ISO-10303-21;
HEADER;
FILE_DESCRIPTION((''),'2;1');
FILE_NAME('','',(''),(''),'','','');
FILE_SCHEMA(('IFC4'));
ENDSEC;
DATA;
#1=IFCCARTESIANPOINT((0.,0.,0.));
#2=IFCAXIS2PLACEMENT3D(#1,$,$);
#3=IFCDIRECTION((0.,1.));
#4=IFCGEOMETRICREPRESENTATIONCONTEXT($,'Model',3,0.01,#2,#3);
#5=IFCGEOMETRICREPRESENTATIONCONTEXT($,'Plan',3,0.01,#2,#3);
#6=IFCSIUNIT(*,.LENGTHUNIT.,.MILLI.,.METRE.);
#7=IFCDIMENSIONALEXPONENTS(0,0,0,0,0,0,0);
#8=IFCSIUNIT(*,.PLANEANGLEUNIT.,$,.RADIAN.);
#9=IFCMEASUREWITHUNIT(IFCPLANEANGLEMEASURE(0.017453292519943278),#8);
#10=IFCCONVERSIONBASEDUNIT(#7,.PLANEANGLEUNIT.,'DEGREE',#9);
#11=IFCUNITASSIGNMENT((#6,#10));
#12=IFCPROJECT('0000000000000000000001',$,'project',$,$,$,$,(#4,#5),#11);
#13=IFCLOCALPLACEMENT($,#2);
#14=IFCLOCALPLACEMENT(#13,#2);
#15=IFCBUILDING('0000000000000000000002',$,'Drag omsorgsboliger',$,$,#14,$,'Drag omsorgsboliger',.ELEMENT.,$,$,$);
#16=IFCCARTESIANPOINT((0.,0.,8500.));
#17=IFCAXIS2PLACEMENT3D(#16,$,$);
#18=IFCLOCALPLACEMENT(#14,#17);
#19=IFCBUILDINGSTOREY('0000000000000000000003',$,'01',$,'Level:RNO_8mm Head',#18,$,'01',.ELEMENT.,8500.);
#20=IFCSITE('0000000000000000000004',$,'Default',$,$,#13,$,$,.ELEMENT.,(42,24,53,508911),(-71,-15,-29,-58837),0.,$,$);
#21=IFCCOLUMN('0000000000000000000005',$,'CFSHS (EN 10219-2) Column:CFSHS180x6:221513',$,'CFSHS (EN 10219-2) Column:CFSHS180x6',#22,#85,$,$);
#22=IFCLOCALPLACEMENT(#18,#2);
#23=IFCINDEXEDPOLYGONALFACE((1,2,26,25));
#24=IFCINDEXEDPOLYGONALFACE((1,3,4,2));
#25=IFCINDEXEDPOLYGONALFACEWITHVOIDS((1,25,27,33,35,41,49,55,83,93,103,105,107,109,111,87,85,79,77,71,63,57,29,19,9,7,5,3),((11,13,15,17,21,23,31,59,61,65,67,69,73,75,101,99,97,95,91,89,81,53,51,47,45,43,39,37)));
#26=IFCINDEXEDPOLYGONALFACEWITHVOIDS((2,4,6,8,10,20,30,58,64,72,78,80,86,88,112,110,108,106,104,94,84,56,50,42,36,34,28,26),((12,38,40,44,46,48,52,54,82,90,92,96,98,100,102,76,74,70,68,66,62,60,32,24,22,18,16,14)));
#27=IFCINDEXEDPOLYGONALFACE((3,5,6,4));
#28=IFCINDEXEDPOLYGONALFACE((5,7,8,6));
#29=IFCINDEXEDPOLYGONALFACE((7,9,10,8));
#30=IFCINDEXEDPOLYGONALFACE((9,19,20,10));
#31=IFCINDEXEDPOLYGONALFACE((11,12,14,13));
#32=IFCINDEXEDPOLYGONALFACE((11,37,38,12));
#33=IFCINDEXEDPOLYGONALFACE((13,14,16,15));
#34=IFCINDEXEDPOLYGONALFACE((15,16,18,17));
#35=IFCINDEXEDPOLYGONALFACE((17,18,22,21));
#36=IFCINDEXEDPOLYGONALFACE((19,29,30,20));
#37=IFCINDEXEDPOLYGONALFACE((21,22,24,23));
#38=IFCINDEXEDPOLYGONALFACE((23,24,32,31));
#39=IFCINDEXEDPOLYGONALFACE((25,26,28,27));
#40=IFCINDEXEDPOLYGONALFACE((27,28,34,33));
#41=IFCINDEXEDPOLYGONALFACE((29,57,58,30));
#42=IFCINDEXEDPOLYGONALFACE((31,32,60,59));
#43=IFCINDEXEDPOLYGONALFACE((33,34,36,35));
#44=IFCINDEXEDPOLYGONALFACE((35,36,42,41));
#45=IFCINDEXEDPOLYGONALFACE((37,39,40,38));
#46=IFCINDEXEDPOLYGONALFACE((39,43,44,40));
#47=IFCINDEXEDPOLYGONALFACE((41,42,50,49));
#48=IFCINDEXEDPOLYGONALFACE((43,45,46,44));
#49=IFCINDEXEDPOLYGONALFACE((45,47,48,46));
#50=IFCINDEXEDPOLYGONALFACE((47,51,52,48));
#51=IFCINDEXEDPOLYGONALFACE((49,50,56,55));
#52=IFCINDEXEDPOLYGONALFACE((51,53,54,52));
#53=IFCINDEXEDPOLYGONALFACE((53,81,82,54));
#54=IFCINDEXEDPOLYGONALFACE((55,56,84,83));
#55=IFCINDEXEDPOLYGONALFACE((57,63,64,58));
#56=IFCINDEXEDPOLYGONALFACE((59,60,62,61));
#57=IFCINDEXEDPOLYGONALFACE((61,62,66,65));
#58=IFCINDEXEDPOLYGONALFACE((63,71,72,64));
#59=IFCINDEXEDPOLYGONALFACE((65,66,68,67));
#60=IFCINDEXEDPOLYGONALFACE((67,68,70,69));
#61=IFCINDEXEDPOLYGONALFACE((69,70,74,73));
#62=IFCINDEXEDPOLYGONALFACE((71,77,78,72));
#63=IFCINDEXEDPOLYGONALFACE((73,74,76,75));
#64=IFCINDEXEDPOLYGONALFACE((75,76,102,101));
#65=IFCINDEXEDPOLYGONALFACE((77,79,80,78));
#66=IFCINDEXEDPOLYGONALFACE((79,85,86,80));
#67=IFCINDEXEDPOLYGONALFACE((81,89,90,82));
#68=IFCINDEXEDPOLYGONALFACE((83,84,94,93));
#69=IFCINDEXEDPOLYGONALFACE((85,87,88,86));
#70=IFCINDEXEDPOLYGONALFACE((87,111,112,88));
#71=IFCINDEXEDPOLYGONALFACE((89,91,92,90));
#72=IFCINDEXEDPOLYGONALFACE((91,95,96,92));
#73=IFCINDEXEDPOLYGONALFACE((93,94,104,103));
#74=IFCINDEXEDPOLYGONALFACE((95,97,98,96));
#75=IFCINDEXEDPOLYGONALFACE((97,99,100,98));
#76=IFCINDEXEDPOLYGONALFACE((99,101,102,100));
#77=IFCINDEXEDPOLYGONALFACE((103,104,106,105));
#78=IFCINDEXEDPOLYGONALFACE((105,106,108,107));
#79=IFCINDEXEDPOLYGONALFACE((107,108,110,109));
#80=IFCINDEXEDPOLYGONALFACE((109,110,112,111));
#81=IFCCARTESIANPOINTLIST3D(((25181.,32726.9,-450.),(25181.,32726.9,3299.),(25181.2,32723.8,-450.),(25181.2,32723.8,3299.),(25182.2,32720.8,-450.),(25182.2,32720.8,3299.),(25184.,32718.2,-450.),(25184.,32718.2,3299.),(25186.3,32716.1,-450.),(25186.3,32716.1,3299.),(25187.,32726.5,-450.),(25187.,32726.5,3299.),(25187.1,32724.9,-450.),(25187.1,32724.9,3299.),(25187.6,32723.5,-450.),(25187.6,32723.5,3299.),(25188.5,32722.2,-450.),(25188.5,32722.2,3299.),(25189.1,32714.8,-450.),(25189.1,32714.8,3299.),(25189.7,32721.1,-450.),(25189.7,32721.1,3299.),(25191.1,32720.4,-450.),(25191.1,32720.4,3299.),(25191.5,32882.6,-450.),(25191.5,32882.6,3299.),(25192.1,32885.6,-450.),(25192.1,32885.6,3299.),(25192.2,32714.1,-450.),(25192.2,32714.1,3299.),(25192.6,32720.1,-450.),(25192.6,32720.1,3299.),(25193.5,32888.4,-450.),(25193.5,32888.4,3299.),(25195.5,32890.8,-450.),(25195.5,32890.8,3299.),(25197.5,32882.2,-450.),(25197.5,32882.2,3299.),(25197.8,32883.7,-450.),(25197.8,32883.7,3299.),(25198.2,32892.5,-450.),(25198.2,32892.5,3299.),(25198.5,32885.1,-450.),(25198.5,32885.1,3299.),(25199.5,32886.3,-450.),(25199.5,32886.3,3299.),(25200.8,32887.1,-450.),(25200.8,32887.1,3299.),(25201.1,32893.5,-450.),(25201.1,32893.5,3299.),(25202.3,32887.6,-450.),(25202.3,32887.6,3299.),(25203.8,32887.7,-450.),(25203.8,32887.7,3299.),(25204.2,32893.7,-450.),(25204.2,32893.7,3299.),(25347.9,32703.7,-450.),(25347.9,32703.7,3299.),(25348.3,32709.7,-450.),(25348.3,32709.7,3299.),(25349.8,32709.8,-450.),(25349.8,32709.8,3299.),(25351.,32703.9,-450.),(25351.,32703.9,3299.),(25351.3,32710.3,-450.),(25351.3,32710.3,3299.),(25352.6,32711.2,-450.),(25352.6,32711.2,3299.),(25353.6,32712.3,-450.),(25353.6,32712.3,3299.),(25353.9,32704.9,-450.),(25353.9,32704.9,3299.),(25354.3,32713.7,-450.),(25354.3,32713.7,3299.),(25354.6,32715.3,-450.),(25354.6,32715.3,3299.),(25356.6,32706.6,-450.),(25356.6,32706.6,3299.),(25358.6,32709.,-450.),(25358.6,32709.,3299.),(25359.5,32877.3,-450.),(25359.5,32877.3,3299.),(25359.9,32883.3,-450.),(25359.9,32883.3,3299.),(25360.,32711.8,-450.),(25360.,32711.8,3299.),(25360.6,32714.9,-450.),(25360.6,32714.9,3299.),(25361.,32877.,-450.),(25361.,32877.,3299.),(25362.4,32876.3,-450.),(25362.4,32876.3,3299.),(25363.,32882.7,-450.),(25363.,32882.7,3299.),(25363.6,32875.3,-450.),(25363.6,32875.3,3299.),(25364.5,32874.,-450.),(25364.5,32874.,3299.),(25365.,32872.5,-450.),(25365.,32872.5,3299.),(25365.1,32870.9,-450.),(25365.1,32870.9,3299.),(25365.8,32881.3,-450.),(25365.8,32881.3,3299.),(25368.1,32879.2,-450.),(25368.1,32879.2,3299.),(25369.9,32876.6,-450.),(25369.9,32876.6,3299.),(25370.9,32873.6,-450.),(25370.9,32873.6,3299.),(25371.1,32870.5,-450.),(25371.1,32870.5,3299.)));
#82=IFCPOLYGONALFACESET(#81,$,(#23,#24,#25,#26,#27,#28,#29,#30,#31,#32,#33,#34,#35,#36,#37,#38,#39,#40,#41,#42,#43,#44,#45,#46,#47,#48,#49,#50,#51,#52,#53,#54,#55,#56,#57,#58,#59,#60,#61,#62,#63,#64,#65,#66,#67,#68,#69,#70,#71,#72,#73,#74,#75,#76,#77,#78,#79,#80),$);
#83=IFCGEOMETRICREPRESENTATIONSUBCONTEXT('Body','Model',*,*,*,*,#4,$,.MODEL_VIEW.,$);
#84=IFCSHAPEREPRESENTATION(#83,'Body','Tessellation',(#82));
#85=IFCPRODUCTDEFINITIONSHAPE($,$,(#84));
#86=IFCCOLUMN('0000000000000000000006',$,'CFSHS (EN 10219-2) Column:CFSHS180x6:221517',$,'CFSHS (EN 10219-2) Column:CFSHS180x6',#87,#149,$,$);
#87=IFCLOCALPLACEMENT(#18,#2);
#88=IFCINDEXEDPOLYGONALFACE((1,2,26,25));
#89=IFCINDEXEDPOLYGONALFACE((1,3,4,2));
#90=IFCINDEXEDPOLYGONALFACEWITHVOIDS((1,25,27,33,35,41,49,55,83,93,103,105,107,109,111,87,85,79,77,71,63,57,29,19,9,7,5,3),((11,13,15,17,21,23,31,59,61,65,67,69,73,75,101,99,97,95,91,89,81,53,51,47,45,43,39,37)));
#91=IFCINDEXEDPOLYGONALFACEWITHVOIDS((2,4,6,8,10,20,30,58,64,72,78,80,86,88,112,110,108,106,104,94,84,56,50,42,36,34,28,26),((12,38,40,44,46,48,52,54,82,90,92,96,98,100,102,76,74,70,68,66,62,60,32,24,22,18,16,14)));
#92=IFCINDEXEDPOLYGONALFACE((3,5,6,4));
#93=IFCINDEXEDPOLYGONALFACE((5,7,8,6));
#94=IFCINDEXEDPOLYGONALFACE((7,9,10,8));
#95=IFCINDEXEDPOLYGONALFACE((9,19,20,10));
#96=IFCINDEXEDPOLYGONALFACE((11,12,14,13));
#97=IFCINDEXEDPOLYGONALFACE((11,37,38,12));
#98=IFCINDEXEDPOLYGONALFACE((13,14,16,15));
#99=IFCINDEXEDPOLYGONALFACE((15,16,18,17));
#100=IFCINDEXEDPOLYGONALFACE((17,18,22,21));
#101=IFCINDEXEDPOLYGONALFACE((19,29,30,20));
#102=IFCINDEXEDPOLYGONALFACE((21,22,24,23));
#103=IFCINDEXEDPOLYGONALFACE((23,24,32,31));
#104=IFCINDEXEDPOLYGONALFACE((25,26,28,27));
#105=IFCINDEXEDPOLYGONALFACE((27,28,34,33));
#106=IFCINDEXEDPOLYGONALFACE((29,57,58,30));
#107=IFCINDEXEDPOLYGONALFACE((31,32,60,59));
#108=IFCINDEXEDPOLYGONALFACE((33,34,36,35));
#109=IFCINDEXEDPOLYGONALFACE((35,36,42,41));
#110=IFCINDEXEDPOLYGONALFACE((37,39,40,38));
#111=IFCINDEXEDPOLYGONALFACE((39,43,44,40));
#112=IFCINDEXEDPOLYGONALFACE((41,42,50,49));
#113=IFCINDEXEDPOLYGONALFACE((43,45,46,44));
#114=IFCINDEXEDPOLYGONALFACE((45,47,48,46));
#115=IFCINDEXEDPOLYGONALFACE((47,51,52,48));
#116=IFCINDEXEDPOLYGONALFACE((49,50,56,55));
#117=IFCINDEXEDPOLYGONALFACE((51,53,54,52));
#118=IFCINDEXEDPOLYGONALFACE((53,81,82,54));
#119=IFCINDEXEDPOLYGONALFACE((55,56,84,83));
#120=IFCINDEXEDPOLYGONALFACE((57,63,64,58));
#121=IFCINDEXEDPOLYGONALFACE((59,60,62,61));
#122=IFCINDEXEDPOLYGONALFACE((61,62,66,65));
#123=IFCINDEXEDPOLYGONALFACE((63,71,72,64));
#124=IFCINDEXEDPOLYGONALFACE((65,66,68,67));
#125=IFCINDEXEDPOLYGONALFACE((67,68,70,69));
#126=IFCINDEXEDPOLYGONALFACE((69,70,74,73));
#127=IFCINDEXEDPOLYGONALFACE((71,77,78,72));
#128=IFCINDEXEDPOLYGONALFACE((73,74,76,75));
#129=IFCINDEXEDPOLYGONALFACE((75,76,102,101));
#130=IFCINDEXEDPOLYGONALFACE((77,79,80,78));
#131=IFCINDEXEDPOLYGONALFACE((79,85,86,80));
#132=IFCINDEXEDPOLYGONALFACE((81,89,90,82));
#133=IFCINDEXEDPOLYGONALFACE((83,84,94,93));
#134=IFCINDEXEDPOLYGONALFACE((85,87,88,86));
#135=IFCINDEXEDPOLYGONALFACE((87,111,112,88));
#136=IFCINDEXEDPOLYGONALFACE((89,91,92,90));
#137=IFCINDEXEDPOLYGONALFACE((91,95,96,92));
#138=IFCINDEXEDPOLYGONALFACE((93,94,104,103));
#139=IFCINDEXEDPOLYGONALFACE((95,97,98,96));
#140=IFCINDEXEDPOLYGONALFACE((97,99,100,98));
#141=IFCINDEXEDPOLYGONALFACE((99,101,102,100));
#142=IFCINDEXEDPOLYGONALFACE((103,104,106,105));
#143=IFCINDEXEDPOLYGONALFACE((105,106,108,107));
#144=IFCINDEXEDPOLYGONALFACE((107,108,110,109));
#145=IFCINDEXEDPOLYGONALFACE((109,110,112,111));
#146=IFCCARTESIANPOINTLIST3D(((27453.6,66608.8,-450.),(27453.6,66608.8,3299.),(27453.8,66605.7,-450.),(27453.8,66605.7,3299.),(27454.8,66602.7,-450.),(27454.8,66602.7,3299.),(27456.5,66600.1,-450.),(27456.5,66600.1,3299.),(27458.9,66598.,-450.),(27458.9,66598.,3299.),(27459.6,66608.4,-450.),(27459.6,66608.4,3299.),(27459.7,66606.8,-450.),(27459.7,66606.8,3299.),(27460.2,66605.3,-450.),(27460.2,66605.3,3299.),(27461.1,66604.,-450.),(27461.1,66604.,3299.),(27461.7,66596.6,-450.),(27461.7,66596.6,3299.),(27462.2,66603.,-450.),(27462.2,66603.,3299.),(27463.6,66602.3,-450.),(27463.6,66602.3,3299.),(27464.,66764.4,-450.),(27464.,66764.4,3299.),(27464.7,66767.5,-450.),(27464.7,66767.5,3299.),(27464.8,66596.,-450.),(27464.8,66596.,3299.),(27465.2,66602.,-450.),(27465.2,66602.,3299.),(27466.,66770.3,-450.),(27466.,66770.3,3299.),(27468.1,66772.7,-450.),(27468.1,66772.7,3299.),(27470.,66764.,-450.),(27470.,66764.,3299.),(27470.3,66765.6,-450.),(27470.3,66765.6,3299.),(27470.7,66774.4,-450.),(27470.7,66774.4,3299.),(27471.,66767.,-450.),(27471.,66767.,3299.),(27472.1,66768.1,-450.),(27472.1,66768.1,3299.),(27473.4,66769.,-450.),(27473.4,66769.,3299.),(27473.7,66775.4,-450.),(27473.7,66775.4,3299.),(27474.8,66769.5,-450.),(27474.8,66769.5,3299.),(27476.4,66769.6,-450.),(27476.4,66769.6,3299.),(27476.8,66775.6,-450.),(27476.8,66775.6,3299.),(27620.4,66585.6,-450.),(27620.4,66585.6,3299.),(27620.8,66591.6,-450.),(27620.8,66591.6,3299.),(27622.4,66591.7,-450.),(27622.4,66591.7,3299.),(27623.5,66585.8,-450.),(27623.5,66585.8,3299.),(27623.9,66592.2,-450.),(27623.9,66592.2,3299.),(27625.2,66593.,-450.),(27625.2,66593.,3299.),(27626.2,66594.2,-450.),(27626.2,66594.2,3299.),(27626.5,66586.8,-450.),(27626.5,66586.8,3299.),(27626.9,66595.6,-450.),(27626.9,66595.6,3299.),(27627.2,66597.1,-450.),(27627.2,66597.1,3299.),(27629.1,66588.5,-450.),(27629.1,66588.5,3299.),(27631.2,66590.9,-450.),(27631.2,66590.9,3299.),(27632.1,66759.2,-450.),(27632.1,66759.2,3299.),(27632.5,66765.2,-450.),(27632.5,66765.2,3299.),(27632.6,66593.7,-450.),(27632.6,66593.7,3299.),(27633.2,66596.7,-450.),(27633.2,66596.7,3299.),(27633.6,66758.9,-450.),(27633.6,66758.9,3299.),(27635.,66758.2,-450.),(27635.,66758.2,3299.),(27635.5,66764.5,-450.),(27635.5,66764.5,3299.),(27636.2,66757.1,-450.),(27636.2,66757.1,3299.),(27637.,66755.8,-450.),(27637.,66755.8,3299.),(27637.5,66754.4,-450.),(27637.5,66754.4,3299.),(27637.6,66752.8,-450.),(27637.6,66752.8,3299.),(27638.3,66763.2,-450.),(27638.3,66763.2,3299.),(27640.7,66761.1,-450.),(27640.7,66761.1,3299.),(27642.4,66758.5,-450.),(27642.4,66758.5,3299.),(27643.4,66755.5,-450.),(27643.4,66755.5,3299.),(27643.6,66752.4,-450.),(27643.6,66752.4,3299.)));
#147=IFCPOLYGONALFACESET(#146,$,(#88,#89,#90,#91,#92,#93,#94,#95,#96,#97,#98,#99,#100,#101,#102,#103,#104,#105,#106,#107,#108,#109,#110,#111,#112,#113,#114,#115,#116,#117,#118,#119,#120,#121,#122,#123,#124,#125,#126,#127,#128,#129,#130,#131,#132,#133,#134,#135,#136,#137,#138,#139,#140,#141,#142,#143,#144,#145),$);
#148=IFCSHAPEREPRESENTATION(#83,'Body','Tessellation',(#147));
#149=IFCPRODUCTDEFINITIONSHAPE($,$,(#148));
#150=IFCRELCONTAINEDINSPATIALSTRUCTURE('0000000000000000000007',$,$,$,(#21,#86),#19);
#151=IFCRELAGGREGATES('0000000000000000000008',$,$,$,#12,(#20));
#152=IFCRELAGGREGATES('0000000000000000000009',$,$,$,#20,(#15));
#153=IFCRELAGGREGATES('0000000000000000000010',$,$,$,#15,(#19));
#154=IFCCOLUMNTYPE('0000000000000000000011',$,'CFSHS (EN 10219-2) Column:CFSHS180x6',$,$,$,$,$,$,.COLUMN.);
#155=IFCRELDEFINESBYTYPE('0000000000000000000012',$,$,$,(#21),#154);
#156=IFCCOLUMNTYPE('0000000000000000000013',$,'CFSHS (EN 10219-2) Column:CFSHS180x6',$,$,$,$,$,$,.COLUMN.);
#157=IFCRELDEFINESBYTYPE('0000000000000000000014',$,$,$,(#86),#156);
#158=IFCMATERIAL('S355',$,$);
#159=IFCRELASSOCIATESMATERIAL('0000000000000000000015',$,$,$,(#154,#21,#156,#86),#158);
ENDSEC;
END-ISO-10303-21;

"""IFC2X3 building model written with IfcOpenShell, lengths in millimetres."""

from ifc_helpers import new_model, entity, si_unit, converted_unit, direction, frame, frame_2d, origin, place, context, subcontext, project, spatial, polyline, circle_curve, parameter, trimmed, segment, composite_curve, outline, extrude, source, transform, mapped, material, type_object, type_shapes, element, save


model = new_model("IFC2X3")

# Units and contexts
model_context = context("Model", 3, precision=0.01, world=origin(), true_north=direction((0.0, 1.0)))
plan_context = context("Plan", 3, precision=0.01, world=origin(), true_north=direction((0.0, 1.0)))
body_context = subcontext(model_context, "Body", "Model", "MODEL_VIEW")
ifc_project = project(units=[si_unit("LENGTHUNIT", "METRE", prefix="MILLI"), converted_unit("PLANEANGLEUNIT", "DEGREE", entity("IfcPlaneAngleMeasure", 0.017453292519943278), si_unit("PLANEANGLEUNIT", "RADIAN"), dimensions=[0, 0, 0, 0, 0, 0, 0])], contexts=[model_context, plan_context])

# Site, building, storey
site_placement = place(None, origin())
site = spatial("IfcSite", under=ifc_project, at=site_placement, Name="Default", CompositionType="ELEMENT", RefLatitude=(42, 24, 53, 508911), RefLongitude=(-71, -15, -29, -58837), RefElevation=0.0)
building_placement = place(site_placement, origin())
building = spatial("IfcBuilding", under=site, at=building_placement, Name="Drag omsorgsboliger", LongName="Drag omsorgsboliger", CompositionType="ELEMENT")
storey_placement = place(building_placement, frame((0.0, 0.0, 8500.0)))
storey = spatial("IfcBuildingStorey", under=building, at=storey_placement, Name="01", ObjectType="Level:RNO_8mm Head", LongName="01", CompositionType="ELEMENT", Elevation=8500.0)

# Columns
ifc_material = material(Name="S355")
column_type_1 = type_object("IfcColumnType", Name="CFSHS (EN 10219-2) Column:CFSHS180x6", PredefinedType="COLUMN", material=ifc_material)
shared_shape_1 = source(origin(), body_context, "Body", "SweptSolid", [
    extrude(outline(composite_curve([segment(polyline([(-78.0, -90.0), (78.0, -90.0)]), True, "CONTINUOUS"), segment(trimmed(circle_curve(frame_2d((78.0, -78.0), x_axis=(-1.0, 0.0)), 12.0), [parameter(90.0)], [parameter(180.0)], True, "PARAMETER"), True, "CONTINUOUS"), segment(polyline([(90.0, -78.0), (90.0, 78.0)]), True, "CONTINUOUS"), segment(trimmed(circle_curve(frame_2d((78.0, 78.0), x_axis=(-1.0, 0.0)), 12.0), [parameter(180.0)], [parameter(270.0)], True, "PARAMETER"), True, "CONTINUOUS"), segment(polyline([(78.0, 90.0), (-78.0, 90.0)]), True, "CONTINUOUS"), segment(trimmed(circle_curve(frame_2d((-78.0, 78.0), x_axis=(-1.0, 0.0)), 12.0), [parameter(270.0)], [parameter(360.0)], True, "PARAMETER"), True, "CONTINUOUS"), segment(polyline([(-90.0, 78.0), (-90.0, -78.0)]), True, "CONTINUOUS"), segment(trimmed(circle_curve(frame_2d((-78.0, -78.0), x_axis=(-1.0, 0.0)), 12.0), [parameter(360.0)], [parameter(90.0)], True, "PARAMETER"), True, "CONTINUOUS")], self_intersect=False), holes=[composite_curve([segment(trimmed(circle_curve(frame_2d((-78.0, -78.0), x_axis=(-1.0, 0.0)), 6.0), [parameter(360.0)], [parameter(90.0)], True, "PARAMETER"), False, "CONTINUOUS"), segment(polyline([(-84.0, -78.0), (-84.0, 78.0)]), True, "CONTINUOUS"), segment(trimmed(circle_curve(frame_2d((-78.0, 78.0), x_axis=(-1.0, 0.0)), 6.0), [parameter(270.0)], [parameter(360.0)], True, "PARAMETER"), False, "CONTINUOUS"), segment(polyline([(-78.0, 84.0), (78.0, 84.0)]), True, "CONTINUOUS"), segment(trimmed(circle_curve(frame_2d((78.0, 78.0), x_axis=(-1.0, 0.0)), 6.0), [parameter(180.0)], [parameter(270.0)], True, "PARAMETER"), False, "CONTINUOUS"), segment(polyline([(84.0, 78.0), (84.0, -78.0)]), True, "CONTINUOUS"), segment(trimmed(circle_curve(frame_2d((78.0, -78.0), x_axis=(-1.0, 0.0)), 6.0), [parameter(90.0)], [parameter(180.0)], True, "PARAMETER"), False, "CONTINUOUS"), segment(polyline([(78.0, -84.0), (-78.0, -84.0)]), True, "CONTINUOUS")], self_intersect=False)]), frame((25276.1, 32798.7, 8050.0), z_axis=(0.0, 0.0, 1.0), x_axis=(-0.997758, 0.066923, 0.0)), (0.0, 0.0, 1.0), 3749.0),
])
type_shapes(column_type_1, [shared_shape_1])
column_1_placement = place(storey_placement, frame((0.0, 0.0, -8500.0)))
element("IfcColumn", 1, at=column_1_placement, inside=storey, type_object=column_type_1, material=ifc_material, Name="CFSHS (EN 10219-2) Column:CFSHS180x6:221513", ObjectType="CFSHS (EN 10219-2) Column:CFSHS180x6", context=body_context, shape_type="MappedRepresentation", body=[
    mapped(shared_shape_1, transform((0.0, 0.0, 0.0), scale=1.0)),
])
column_type_2 = type_object("IfcColumnType", Name="CFSHS (EN 10219-2) Column:CFSHS180x6", PredefinedType="COLUMN", material=ifc_material)
shared_shape_2 = source(origin(), body_context, "Body", "SweptSolid", [
    extrude(outline(composite_curve([segment(polyline([(-78.0, -90.0), (78.0, -90.0)]), True, "CONTINUOUS"), segment(trimmed(circle_curve(frame_2d((78.0, -78.0), x_axis=(-1.0, 0.0)), 12.0), [parameter(90.0)], [parameter(180.0)], True, "PARAMETER"), True, "CONTINUOUS"), segment(polyline([(90.0, -78.0), (90.0, 78.0)]), True, "CONTINUOUS"), segment(trimmed(circle_curve(frame_2d((78.0, 78.0), x_axis=(-1.0, 0.0)), 12.0), [parameter(180.0)], [parameter(270.0)], True, "PARAMETER"), True, "CONTINUOUS"), segment(polyline([(78.0, 90.0), (-78.0, 90.0)]), True, "CONTINUOUS"), segment(trimmed(circle_curve(frame_2d((-78.0, 78.0), x_axis=(-1.0, 0.0)), 12.0), [parameter(270.0)], [parameter(360.0)], True, "PARAMETER"), True, "CONTINUOUS"), segment(polyline([(-90.0, 78.0), (-90.0, -78.0)]), True, "CONTINUOUS"), segment(trimmed(circle_curve(frame_2d((-78.0, -78.0), x_axis=(-1.0, 0.0)), 12.0), [parameter(360.0)], [parameter(90.0)], True, "PARAMETER"), True, "CONTINUOUS")], self_intersect=False), holes=[composite_curve([segment(trimmed(circle_curve(frame_2d((-78.0, -78.0), x_axis=(-1.0, 0.0)), 6.0), [parameter(360.0)], [parameter(90.0)], True, "PARAMETER"), False, "CONTINUOUS"), segment(polyline([(-84.0, -78.0), (-84.0, 78.0)]), True, "CONTINUOUS"), segment(trimmed(circle_curve(frame_2d((-78.0, 78.0), x_axis=(-1.0, 0.0)), 6.0), [parameter(270.0)], [parameter(360.0)], True, "PARAMETER"), False, "CONTINUOUS"), segment(polyline([(-78.0, 84.0), (78.0, 84.0)]), True, "CONTINUOUS"), segment(trimmed(circle_curve(frame_2d((78.0, 78.0), x_axis=(-1.0, 0.0)), 6.0), [parameter(180.0)], [parameter(270.0)], True, "PARAMETER"), False, "CONTINUOUS"), segment(polyline([(84.0, 78.0), (84.0, -78.0)]), True, "CONTINUOUS"), segment(trimmed(circle_curve(frame_2d((78.0, -78.0), x_axis=(-1.0, 0.0)), 6.0), [parameter(90.0)], [parameter(180.0)], True, "PARAMETER"), False, "CONTINUOUS"), segment(polyline([(78.0, -84.0), (-78.0, -84.0)]), True, "CONTINUOUS")], self_intersect=False)]), frame((27548.6, 66680.6, 8050.0), z_axis=(0.0, 0.0, 1.0), x_axis=(-0.997758, 0.066923, 0.0)), (0.0, 0.0, 1.0), 3749.0),
])
type_shapes(column_type_2, [shared_shape_2])
column_2_placement = place(storey_placement, frame((0.0, 0.0, -8500.0)))
element("IfcColumn", 2, at=column_2_placement, inside=storey, type_object=column_type_2, material=ifc_material, Name="CFSHS (EN 10219-2) Column:CFSHS180x6:221517", ObjectType="CFSHS (EN 10219-2) Column:CFSHS180x6", context=body_context, shape_type="MappedRepresentation", body=[
    mapped(shared_shape_2, transform((0.0, 0.0, 0.0), scale=1.0)),
])

save(model, "model.ifc")
